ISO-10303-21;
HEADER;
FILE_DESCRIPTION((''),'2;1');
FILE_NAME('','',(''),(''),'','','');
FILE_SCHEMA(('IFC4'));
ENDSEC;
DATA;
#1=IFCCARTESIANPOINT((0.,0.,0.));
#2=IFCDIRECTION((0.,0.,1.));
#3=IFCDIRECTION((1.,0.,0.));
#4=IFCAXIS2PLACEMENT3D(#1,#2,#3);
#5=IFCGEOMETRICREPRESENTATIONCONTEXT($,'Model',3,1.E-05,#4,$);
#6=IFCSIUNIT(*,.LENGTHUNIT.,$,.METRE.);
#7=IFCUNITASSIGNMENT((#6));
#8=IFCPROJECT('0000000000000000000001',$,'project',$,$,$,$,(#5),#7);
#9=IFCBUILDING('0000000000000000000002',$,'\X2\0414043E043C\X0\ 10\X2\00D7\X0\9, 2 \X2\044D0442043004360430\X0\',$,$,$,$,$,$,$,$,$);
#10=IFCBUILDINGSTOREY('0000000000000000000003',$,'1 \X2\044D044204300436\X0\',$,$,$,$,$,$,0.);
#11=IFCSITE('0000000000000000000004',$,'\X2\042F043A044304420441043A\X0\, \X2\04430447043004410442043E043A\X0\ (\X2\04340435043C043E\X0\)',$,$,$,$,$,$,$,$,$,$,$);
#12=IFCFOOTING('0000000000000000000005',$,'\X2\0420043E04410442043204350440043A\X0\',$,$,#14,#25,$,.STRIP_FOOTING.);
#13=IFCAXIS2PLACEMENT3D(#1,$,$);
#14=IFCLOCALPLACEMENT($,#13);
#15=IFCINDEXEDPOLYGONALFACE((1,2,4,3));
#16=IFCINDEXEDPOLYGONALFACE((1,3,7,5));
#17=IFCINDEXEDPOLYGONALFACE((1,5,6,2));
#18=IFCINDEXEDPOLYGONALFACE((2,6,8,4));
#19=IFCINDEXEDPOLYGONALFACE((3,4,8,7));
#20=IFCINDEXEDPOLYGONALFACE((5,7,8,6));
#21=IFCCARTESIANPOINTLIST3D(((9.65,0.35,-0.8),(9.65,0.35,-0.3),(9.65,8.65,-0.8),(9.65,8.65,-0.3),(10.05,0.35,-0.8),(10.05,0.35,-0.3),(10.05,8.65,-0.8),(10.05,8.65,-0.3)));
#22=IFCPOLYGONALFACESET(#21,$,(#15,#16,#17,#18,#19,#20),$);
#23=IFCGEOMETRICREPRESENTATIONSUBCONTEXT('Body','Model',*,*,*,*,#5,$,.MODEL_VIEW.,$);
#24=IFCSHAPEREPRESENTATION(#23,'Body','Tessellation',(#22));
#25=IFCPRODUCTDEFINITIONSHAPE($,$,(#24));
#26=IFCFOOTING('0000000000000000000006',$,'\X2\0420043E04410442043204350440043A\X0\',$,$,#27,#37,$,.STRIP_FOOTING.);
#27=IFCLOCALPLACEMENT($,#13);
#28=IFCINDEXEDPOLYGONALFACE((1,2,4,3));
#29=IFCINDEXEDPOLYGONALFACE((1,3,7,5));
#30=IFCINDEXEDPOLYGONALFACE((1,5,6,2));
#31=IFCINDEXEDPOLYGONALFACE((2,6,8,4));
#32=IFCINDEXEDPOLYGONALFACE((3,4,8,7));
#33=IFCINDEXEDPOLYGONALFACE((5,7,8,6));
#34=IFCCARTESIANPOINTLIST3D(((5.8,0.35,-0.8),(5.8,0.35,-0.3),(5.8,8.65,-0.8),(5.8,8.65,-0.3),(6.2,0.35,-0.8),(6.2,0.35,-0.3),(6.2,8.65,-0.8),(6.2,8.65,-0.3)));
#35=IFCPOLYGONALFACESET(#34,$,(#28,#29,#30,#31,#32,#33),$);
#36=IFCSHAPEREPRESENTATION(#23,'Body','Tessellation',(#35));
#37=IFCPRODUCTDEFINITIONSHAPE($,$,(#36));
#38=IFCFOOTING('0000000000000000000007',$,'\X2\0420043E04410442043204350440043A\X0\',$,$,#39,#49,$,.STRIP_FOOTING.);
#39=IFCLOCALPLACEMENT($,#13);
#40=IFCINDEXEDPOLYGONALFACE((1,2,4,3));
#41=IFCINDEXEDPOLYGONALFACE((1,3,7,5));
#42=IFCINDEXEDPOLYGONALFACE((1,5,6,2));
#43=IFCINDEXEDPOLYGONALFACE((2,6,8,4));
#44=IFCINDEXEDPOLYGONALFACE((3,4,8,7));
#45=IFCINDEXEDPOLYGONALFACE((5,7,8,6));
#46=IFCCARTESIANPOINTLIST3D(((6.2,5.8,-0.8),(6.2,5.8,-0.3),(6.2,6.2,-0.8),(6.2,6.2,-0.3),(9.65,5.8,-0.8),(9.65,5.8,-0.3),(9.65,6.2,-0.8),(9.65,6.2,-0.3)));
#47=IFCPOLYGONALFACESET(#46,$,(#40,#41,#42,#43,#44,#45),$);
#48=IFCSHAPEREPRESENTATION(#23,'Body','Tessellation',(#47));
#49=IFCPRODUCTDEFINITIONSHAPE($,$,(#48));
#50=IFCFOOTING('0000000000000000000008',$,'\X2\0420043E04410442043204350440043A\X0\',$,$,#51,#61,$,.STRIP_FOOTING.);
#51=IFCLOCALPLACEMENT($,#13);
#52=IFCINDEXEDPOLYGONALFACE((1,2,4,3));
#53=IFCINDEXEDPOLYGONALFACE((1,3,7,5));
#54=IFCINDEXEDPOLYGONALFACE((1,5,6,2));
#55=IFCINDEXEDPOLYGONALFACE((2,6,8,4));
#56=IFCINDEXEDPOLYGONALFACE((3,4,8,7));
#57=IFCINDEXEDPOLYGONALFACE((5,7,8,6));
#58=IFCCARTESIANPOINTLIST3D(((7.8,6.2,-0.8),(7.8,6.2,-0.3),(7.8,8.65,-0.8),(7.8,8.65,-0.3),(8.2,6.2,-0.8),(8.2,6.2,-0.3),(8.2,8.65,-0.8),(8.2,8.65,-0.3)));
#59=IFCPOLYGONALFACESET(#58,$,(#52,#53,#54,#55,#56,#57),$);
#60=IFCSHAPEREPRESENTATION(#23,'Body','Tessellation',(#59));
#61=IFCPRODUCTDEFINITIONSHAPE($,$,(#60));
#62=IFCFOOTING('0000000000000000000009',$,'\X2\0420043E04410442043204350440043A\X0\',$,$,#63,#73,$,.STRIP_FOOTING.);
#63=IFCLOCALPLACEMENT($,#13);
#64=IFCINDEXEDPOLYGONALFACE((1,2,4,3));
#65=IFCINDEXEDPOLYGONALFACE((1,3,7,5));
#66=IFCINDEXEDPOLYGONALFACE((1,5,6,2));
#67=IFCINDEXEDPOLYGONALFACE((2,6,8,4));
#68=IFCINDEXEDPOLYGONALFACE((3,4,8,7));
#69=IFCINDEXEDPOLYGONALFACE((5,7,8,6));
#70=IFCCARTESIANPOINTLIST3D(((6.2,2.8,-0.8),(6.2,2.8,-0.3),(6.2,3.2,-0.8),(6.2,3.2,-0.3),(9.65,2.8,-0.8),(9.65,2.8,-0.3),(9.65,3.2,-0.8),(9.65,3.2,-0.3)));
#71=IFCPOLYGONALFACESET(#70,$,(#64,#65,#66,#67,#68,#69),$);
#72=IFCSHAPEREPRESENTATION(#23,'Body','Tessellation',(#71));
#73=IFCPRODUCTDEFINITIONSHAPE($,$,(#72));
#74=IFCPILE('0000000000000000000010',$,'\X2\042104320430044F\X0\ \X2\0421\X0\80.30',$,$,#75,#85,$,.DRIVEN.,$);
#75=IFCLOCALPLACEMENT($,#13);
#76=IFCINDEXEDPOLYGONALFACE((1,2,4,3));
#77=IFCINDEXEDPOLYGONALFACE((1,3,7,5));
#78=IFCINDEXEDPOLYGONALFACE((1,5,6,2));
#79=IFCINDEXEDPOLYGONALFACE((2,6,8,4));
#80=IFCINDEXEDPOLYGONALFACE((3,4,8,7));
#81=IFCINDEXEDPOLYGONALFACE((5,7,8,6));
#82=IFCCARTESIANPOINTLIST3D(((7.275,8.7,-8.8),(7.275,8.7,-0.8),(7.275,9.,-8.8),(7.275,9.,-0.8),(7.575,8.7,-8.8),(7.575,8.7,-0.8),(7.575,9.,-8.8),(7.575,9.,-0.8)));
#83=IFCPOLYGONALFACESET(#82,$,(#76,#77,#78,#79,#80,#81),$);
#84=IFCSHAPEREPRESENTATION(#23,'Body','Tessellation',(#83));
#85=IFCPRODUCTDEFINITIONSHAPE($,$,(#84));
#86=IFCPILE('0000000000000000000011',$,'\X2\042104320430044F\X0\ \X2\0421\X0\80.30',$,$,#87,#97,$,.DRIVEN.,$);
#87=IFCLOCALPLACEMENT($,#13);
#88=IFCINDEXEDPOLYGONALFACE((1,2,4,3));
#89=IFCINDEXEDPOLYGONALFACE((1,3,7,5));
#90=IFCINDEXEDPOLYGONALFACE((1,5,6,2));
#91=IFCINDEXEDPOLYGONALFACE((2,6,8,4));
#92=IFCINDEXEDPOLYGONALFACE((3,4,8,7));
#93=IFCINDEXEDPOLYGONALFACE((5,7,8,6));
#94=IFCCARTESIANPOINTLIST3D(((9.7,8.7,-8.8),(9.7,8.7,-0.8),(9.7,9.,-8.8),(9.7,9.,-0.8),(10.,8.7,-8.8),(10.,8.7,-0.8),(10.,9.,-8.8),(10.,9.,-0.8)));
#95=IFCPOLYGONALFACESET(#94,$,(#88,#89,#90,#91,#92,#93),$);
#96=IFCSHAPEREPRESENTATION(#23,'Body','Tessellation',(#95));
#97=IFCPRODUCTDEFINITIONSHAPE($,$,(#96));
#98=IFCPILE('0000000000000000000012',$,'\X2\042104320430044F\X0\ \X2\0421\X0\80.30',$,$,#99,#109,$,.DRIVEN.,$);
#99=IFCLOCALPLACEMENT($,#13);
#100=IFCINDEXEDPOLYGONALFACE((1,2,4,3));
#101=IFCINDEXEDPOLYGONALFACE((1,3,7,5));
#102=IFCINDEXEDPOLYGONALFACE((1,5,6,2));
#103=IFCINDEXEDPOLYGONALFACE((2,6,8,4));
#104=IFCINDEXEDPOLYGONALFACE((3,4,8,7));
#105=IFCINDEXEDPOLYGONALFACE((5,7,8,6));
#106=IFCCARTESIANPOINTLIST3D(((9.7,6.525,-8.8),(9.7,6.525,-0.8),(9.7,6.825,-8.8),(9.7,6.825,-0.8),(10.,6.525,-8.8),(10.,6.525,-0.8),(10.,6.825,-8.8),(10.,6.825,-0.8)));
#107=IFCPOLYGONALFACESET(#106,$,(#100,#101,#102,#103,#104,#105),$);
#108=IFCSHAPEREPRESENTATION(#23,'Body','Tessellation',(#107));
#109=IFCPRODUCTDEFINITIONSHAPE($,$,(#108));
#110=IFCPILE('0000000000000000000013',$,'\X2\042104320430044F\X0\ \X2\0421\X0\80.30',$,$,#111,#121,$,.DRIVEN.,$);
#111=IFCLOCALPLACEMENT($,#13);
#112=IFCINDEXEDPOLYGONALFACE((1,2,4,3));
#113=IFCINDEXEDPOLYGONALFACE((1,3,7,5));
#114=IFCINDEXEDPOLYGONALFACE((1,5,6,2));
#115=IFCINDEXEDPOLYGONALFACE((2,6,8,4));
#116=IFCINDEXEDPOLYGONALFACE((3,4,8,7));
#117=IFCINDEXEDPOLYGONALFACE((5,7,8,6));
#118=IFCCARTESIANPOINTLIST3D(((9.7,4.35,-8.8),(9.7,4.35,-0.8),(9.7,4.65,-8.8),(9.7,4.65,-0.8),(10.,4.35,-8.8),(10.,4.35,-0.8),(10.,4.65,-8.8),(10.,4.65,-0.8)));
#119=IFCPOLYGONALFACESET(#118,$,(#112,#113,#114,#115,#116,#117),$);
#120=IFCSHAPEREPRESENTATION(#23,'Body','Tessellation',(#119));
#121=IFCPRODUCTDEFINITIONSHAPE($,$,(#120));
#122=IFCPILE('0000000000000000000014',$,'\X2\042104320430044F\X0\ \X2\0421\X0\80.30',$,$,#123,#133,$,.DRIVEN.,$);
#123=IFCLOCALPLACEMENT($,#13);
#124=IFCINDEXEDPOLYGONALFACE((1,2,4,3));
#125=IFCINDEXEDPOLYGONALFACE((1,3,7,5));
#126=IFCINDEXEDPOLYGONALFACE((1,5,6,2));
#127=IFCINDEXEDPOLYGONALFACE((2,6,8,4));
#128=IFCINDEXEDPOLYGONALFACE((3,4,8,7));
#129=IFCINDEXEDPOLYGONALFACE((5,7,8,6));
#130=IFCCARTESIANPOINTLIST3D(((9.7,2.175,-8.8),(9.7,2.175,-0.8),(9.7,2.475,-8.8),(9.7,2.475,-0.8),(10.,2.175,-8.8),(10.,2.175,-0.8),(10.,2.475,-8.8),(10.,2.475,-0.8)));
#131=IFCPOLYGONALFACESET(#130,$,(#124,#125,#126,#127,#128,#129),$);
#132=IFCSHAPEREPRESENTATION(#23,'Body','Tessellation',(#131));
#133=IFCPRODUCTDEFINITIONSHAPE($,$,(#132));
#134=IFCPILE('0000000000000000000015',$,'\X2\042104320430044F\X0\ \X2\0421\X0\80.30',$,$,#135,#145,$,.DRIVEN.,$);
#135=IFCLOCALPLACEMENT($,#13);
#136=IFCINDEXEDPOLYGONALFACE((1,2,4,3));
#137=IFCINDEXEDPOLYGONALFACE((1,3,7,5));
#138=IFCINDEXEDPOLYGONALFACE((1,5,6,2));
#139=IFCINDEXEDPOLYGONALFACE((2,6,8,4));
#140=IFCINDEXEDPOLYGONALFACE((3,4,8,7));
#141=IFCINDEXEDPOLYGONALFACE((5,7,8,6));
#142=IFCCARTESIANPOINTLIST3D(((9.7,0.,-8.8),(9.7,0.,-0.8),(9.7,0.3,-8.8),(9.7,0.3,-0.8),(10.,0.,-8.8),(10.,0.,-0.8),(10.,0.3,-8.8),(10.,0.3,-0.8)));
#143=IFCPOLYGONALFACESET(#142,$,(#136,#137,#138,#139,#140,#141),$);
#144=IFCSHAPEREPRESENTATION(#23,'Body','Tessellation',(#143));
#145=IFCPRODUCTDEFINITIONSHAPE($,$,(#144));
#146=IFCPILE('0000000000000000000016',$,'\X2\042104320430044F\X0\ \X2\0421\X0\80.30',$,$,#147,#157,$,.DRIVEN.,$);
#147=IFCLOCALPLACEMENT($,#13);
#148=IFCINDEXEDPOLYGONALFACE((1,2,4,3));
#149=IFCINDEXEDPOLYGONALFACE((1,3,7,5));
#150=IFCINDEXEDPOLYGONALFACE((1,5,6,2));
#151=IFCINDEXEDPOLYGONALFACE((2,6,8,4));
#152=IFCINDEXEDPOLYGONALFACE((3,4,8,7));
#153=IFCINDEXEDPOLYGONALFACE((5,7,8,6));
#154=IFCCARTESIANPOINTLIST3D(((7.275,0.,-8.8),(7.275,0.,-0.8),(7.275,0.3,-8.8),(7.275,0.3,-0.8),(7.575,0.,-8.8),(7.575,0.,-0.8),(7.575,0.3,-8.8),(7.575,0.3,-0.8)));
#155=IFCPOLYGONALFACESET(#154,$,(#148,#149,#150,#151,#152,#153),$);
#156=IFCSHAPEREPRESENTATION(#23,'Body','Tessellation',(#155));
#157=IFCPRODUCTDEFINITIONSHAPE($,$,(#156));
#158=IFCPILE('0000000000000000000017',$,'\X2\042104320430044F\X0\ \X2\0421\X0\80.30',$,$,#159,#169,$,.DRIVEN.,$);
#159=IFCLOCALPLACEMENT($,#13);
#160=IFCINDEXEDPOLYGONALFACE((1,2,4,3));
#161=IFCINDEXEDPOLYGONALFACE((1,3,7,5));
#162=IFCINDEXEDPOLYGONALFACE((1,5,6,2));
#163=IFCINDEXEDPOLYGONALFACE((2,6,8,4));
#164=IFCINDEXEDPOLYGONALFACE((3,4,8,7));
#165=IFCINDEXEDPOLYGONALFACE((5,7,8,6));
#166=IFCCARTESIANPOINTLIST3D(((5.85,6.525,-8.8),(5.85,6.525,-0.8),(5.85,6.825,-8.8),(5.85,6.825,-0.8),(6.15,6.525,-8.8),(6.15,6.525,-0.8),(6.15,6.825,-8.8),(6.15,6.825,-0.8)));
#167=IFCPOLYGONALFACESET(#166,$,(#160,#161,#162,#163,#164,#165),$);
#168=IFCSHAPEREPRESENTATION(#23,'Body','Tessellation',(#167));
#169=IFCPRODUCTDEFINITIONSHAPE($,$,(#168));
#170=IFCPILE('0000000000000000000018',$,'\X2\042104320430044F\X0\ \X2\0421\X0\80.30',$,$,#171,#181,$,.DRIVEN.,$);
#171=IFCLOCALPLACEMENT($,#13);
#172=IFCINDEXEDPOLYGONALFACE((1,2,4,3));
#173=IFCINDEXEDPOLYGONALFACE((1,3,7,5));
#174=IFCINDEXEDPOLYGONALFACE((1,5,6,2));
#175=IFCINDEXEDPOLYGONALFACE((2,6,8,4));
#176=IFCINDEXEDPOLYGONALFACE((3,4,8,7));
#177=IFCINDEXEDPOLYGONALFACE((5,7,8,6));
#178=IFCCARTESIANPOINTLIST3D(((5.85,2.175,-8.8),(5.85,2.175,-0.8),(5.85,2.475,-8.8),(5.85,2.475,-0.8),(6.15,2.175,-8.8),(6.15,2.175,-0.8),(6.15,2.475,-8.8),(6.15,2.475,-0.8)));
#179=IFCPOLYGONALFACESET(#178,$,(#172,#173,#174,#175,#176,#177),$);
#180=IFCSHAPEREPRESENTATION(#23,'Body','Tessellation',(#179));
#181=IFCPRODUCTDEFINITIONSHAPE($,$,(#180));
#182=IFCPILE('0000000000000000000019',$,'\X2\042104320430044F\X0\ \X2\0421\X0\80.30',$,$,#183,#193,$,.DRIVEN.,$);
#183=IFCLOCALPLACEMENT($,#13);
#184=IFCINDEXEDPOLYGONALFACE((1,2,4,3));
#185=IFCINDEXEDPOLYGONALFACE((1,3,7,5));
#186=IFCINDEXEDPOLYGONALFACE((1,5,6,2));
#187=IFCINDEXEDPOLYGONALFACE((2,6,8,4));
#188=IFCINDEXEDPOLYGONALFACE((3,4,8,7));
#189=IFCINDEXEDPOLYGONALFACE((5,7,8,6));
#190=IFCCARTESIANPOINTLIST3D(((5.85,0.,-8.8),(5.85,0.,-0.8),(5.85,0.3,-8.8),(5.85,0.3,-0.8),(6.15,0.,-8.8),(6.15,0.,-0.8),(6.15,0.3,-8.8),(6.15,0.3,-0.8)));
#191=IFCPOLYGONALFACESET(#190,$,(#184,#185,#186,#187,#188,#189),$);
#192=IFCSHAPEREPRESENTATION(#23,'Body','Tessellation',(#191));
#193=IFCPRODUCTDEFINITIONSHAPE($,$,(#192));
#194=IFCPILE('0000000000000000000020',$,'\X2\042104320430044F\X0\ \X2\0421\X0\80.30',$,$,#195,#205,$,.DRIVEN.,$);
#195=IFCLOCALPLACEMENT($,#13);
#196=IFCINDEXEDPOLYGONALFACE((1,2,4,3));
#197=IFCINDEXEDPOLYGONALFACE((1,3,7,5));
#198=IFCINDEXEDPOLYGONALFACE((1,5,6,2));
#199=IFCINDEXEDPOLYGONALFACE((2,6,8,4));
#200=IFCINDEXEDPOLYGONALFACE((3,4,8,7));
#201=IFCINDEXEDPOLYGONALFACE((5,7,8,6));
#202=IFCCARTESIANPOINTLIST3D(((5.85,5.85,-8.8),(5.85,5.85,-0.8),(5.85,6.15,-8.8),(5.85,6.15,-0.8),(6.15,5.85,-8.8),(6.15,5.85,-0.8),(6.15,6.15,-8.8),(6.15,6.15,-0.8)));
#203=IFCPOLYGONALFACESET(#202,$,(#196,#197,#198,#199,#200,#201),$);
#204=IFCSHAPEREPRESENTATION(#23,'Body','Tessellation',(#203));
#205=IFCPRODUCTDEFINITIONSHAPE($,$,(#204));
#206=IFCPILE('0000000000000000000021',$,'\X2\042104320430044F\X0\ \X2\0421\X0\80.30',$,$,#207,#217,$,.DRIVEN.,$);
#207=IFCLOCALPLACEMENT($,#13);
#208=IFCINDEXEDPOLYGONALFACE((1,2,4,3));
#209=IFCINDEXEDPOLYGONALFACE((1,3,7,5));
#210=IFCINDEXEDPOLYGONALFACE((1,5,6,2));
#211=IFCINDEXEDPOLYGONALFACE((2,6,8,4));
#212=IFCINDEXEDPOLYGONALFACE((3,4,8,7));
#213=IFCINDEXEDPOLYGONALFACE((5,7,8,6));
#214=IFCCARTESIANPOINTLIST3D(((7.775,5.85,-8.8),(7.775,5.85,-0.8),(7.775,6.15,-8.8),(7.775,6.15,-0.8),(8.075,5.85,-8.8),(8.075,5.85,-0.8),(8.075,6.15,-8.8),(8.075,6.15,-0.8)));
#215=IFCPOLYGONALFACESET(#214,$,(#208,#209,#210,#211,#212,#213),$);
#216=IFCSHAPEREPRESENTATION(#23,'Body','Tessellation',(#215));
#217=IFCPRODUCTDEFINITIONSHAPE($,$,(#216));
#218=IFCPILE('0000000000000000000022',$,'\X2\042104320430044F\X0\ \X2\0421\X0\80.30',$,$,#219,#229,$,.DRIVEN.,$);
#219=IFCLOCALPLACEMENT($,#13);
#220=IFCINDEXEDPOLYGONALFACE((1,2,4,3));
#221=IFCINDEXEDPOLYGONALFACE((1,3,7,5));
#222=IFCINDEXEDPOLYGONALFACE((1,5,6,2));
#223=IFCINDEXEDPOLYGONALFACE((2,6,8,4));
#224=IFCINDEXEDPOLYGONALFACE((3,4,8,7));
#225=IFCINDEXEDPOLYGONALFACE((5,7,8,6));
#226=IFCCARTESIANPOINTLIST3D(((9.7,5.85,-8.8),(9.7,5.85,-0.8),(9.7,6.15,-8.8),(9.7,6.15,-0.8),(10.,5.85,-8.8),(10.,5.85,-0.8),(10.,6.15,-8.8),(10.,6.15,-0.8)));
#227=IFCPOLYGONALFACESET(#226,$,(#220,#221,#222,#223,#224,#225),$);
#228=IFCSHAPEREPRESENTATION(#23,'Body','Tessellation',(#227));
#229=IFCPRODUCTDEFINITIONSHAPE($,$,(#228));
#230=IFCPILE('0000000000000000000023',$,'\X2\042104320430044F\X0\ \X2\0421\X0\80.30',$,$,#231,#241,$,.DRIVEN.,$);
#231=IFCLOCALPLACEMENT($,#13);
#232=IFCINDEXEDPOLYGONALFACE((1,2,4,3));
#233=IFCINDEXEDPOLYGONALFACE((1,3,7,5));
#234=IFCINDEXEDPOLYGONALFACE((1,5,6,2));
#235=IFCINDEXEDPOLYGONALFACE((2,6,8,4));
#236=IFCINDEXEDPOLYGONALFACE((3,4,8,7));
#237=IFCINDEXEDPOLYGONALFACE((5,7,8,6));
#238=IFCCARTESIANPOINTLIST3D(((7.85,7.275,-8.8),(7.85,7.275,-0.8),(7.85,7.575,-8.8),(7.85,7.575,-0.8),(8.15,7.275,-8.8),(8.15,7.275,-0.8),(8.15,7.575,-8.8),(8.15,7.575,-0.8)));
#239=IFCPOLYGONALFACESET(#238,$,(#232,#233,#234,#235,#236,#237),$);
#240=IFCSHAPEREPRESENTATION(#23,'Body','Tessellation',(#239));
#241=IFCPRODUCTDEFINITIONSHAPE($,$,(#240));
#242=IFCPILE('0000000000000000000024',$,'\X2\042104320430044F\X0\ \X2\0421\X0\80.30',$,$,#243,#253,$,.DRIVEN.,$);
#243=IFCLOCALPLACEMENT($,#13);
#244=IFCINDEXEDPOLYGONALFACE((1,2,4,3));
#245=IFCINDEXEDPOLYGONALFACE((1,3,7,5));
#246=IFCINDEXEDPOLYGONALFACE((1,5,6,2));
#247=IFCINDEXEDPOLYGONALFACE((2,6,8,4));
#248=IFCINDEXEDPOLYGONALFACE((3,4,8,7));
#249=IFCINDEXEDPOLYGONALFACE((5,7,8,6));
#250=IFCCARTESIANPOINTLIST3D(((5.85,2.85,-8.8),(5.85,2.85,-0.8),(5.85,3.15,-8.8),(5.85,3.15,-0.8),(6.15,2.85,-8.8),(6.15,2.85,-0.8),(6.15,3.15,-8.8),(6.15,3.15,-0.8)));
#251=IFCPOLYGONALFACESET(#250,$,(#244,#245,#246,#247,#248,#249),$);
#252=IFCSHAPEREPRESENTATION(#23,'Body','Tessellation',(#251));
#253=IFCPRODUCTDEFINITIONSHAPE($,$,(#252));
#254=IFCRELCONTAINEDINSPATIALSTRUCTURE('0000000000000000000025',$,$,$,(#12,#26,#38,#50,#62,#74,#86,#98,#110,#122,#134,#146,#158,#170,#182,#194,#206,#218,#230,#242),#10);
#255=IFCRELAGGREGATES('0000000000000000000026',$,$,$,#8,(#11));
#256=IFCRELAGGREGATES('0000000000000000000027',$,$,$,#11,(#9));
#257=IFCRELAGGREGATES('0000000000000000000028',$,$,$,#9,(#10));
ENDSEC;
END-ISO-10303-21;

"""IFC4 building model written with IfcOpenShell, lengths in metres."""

from ifc_helpers import new_model, si_unit, frame, origin_with_axes, place, context, subcontext, project, spatial, indexed_curve, rectangle, outline, extrude, element, save


model = new_model("IFC4")

# Units and contexts
model_context = context("Model", 3, precision=1e-05, world=origin_with_axes())
body_context = subcontext(model_context, "Body", "Model", "MODEL_VIEW")
ifc_project = project(units=[si_unit("LENGTHUNIT", "METRE")], contexts=[model_context])

# Site, building, storey
site = spatial("IfcSite", under=ifc_project, Name="Якутск, участок (демо)")
building = spatial("IfcBuilding", under=site, Name="Дом 10×9, 2 этажа")
storey = spatial("IfcBuildingStorey", under=building, Name="1 этаж", Elevation=0.0)

# Footings
footing_1_placement = place(None, frame((10.05, 0.35, -0.8), z_axis=(0.0, 0.0, 1.0), x_axis=(0.0, 1.0, 0.0)))
element("IfcFooting", 1, at=footing_1_placement, inside=storey, Name="Ростверк", PredefinedType="STRIP_FOOTING", context=body_context, shape_type="SweptSolid", body=[
    extrude(outline(indexed_curve([(0.0, 0.0), (0.0, 0.4), (8.3, 0.4), (8.3, 0.0), (0.0, 0.0)], self_intersect=False)), origin_with_axes(), (0.0, 0.0, 1.0), 0.5),
])
footing_2_placement = place(None, frame((6.2, 0.35, -0.8), z_axis=(0.0, 0.0, 1.0), x_axis=(0.0, 1.0, 0.0)))
element("IfcFooting", 2, at=footing_2_placement, inside=storey, Name="Ростверк", PredefinedType="STRIP_FOOTING", context=body_context, shape_type="SweptSolid", body=[
    extrude(outline(indexed_curve([(0.0, 0.0), (0.0, 0.4), (8.3, 0.4), (8.3, 0.0), (0.0, 0.0)], self_intersect=False)), origin_with_axes(), (0.0, 0.0, 1.0), 0.5),
])
footing_3_placement = place(None, frame((6.2, 5.8, -0.8), z_axis=(0.0, 0.0, 1.0), x_axis=(1.0, 0.0, 0.0)))
element("IfcFooting", 3, at=footing_3_placement, inside=storey, Name="Ростверк", PredefinedType="STRIP_FOOTING", context=body_context, shape_type="SweptSolid", body=[
    extrude(outline(indexed_curve([(0.0, 0.0), (0.0, 0.4), (3.45, 0.4), (3.45, 0.0), (0.0, 0.0)], self_intersect=False)), origin_with_axes(), (0.0, 0.0, 1.0), 0.5),
])
footing_4_placement = place(None, frame((8.2, 6.2, -0.8), z_axis=(0.0, 0.0, 1.0), x_axis=(0.0, 1.0, 0.0)))
element("IfcFooting", 4, at=footing_4_placement, inside=storey, Name="Ростверк", PredefinedType="STRIP_FOOTING", context=body_context, shape_type="SweptSolid", body=[
    extrude(outline(indexed_curve([(0.0, 0.0), (0.0, 0.4), (2.45, 0.4), (2.45, 0.0), (0.0, 0.0)], self_intersect=False)), origin_with_axes(), (0.0, 0.0, 1.0), 0.5),
])
footing_5_placement = place(None, frame((6.2, 2.8, -0.8), z_axis=(0.0, 0.0, 1.0), x_axis=(1.0, 0.0, 0.0)))
element("IfcFooting", 5, at=footing_5_placement, inside=storey, Name="Ростверк", PredefinedType="STRIP_FOOTING", context=body_context, shape_type="SweptSolid", body=[
    extrude(outline(indexed_curve([(0.0, 0.0), (0.0, 0.4), (3.45, 0.4), (3.45, 0.0), (0.0, 0.0)], self_intersect=False)), origin_with_axes(), (0.0, 0.0, 1.0), 0.5),
])

# Piles
for number, where, z_axis, x_axis, name in (
    (6, (7.425, 8.85, -8.8), (0.0, 0.0, 1.0), (1.0, 0.0, 0.0), "Свая С80.30"),
    (7, (9.85, 8.85, -8.8), (0.0, 0.0, 1.0), (1.0, 0.0, 0.0), "Свая С80.30"),
    (8, (9.85, 6.675, -8.8), (0.0, 0.0, 1.0), (1.0, 0.0, 0.0), "Свая С80.30"),
    (9, (9.85, 4.5, -8.8), (0.0, 0.0, 1.0), (1.0, 0.0, 0.0), "Свая С80.30"),
    (10, (9.85, 2.325, -8.8), (0.0, 0.0, 1.0), (1.0, 0.0, 0.0), "Свая С80.30"),
    (11, (9.85, 0.15, -8.8), (0.0, 0.0, 1.0), (1.0, 0.0, 0.0), "Свая С80.30"),
    (12, (7.425, 0.15, -8.8), (0.0, 0.0, 1.0), (1.0, 0.0, 0.0), "Свая С80.30"),
    (13, (6.0, 6.675, -8.8), (0.0, 0.0, 1.0), (1.0, 0.0, 0.0), "Свая С80.30"),
    (14, (6.0, 2.325, -8.8), (0.0, 0.0, 1.0), (1.0, 0.0, 0.0), "Свая С80.30"),
    (15, (6.0, 0.15, -8.8), (0.0, 0.0, 1.0), (1.0, 0.0, 0.0), "Свая С80.30"),
    (16, (6.0, 6.0, -8.8), (0.0, 0.0, 1.0), (1.0, 0.0, 0.0), "Свая С80.30"),
    (17, (7.925, 6.0, -8.8), (0.0, 0.0, 1.0), (1.0, 0.0, 0.0), "Свая С80.30"),
    (18, (9.85, 6.0, -8.8), (0.0, 0.0, 1.0), (1.0, 0.0, 0.0), "Свая С80.30"),
    (19, (8.0, 7.425, -8.8), (0.0, 0.0, 1.0), (1.0, 0.0, 0.0), "Свая С80.30"),
    (20, (6.0, 3.0, -8.8), (0.0, 0.0, 1.0), (1.0, 0.0, 0.0), "Свая С80.30"),
):
    element("IfcPile", number, at=place(None, frame(where, z_axis=z_axis, x_axis=x_axis)), inside=storey, Name=name, PredefinedType="DRIVEN", context=body_context, shape_type="SweptSolid", body=[
        extrude(rectangle(XDim=0.3, YDim=0.3), origin_with_axes(), (0.0, 0.0, 1.0), 8.0),
    ])

save(model, "model.ifc")
